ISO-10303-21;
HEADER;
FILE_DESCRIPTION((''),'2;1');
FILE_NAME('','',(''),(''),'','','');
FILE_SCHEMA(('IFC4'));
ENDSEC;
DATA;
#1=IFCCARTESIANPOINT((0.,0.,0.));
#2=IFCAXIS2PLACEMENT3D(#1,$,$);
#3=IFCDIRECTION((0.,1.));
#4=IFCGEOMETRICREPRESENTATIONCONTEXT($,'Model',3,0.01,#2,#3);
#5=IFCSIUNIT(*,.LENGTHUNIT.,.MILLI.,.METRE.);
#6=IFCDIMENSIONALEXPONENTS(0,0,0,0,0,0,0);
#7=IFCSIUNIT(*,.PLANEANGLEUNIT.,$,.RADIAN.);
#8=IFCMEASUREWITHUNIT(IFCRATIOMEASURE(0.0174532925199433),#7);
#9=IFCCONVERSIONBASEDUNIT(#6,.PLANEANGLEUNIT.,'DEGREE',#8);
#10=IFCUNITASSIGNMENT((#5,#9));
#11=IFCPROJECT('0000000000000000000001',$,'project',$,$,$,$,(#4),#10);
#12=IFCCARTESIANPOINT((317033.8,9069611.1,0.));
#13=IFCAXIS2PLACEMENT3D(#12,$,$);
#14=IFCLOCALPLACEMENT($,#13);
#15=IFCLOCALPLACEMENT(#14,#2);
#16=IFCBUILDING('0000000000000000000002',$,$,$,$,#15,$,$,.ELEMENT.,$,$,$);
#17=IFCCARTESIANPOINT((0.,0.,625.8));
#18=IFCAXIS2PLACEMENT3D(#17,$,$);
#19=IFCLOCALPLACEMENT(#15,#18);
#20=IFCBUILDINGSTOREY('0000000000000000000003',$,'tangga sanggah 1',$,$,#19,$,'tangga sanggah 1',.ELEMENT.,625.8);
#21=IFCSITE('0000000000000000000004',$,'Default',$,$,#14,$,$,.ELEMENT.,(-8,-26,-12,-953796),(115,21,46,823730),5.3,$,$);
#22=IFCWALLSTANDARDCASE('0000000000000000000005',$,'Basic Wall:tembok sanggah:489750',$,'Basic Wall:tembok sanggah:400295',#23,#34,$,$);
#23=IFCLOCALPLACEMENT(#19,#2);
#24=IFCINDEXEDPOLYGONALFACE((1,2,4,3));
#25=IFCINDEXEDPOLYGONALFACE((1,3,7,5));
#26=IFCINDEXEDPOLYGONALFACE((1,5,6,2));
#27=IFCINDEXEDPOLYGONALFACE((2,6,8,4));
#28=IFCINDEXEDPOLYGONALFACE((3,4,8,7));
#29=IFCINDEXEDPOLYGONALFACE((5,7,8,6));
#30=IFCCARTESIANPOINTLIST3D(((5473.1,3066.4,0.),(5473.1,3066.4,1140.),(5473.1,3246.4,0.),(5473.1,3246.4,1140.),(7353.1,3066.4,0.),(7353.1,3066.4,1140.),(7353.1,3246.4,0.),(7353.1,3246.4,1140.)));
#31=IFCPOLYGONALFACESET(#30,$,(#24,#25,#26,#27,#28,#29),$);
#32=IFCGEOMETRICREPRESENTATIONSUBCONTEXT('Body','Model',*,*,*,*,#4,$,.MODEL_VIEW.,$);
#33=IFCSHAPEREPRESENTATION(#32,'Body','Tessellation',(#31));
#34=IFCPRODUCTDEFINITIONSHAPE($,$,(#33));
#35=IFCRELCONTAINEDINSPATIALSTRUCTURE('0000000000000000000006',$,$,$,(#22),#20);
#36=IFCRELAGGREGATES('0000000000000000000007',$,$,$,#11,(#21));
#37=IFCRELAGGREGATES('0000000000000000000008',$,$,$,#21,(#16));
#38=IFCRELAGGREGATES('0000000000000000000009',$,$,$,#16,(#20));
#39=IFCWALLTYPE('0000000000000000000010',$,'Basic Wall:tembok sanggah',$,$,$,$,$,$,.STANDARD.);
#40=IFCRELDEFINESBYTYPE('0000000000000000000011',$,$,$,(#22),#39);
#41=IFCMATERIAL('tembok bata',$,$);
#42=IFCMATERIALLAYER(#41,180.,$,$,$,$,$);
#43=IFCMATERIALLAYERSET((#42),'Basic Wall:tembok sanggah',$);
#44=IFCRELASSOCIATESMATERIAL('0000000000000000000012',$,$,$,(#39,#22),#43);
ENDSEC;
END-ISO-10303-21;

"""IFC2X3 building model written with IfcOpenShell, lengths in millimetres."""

from ifc_helpers import new_model, entity, si_unit, converted_unit, direction, frame, frame_2d, origin, place, context, subcontext, project, spatial, rectangle, extrude, material, layer, layer_set, layer_usage, type_object, element, save


model = new_model("IFC2X3")

# Units and contexts
model_context = context("Model", 3, precision=0.01, world=origin(), true_north=direction((0.0, 1.0)))
body_context = subcontext(model_context, "Body", "Model", "MODEL_VIEW")
ifc_project = project(units=[si_unit("LENGTHUNIT", "METRE", prefix="MILLI"), converted_unit("PLANEANGLEUNIT", "DEGREE", entity("IfcRatioMeasure", 0.0174532925199433), si_unit("PLANEANGLEUNIT", "RADIAN"), dimensions=[0, 0, 0, 0, 0, 0, 0])], contexts=[model_context])

# Site, building, storey
site_placement = place(None, frame((317033.8, 9069611.1, 0.0)))
site = spatial("IfcSite", under=ifc_project, at=site_placement, Name="Default", CompositionType="ELEMENT", RefLatitude=(-8, -26, -12, -953796), RefLongitude=(115, 21, 46, 823730), RefElevation=5.3)
building_placement = place(site_placement, origin())
building = spatial("IfcBuilding", under=site, at=building_placement, CompositionType="ELEMENT")
storey_placement = place(building_placement, frame((0.0, 0.0, 625.8)))
storey = spatial("IfcBuildingStorey", under=building, at=storey_placement, Name="tangga sanggah 1", LongName="tangga sanggah 1", CompositionType="ELEMENT", Elevation=625.8)

# Wall
ifc_material_1 = material(Name="tembok bata")
ifc_layer_1 = layer(ifc_material_1, 180.0)
ifc_layer_set_1 = layer_set([ifc_layer_1], Name="Basic Wall:tembok sanggah")
ifc_layer_usage_1 = layer_usage(ifc_layer_set_1, "AXIS2", "NEGATIVE", 90.0)
wall_type = type_object("IfcWallType", Name="Basic Wall:tembok sanggah", PredefinedType="STANDARD", material=ifc_layer_set_1)
wall_placement = place(storey_placement, frame((5473.1, 3156.4, 0.0)))
element("IfcWallStandardCase", 1, at=wall_placement, inside=storey, type_object=wall_type, material=ifc_layer_usage_1, Name="Basic Wall:tembok sanggah:489750", ObjectType="Basic Wall:tembok sanggah:400295", context=body_context, shape_type="SweptSolid", body=[
    extrude(rectangle(XDim=1880.0, YDim=180.0, at=frame_2d((940.0, 0.0), x_axis=(-1.0, 0.0))), origin(), (0.0, 0.0, 1.0), 1140.0),
])

save(model, "model.ifc")
